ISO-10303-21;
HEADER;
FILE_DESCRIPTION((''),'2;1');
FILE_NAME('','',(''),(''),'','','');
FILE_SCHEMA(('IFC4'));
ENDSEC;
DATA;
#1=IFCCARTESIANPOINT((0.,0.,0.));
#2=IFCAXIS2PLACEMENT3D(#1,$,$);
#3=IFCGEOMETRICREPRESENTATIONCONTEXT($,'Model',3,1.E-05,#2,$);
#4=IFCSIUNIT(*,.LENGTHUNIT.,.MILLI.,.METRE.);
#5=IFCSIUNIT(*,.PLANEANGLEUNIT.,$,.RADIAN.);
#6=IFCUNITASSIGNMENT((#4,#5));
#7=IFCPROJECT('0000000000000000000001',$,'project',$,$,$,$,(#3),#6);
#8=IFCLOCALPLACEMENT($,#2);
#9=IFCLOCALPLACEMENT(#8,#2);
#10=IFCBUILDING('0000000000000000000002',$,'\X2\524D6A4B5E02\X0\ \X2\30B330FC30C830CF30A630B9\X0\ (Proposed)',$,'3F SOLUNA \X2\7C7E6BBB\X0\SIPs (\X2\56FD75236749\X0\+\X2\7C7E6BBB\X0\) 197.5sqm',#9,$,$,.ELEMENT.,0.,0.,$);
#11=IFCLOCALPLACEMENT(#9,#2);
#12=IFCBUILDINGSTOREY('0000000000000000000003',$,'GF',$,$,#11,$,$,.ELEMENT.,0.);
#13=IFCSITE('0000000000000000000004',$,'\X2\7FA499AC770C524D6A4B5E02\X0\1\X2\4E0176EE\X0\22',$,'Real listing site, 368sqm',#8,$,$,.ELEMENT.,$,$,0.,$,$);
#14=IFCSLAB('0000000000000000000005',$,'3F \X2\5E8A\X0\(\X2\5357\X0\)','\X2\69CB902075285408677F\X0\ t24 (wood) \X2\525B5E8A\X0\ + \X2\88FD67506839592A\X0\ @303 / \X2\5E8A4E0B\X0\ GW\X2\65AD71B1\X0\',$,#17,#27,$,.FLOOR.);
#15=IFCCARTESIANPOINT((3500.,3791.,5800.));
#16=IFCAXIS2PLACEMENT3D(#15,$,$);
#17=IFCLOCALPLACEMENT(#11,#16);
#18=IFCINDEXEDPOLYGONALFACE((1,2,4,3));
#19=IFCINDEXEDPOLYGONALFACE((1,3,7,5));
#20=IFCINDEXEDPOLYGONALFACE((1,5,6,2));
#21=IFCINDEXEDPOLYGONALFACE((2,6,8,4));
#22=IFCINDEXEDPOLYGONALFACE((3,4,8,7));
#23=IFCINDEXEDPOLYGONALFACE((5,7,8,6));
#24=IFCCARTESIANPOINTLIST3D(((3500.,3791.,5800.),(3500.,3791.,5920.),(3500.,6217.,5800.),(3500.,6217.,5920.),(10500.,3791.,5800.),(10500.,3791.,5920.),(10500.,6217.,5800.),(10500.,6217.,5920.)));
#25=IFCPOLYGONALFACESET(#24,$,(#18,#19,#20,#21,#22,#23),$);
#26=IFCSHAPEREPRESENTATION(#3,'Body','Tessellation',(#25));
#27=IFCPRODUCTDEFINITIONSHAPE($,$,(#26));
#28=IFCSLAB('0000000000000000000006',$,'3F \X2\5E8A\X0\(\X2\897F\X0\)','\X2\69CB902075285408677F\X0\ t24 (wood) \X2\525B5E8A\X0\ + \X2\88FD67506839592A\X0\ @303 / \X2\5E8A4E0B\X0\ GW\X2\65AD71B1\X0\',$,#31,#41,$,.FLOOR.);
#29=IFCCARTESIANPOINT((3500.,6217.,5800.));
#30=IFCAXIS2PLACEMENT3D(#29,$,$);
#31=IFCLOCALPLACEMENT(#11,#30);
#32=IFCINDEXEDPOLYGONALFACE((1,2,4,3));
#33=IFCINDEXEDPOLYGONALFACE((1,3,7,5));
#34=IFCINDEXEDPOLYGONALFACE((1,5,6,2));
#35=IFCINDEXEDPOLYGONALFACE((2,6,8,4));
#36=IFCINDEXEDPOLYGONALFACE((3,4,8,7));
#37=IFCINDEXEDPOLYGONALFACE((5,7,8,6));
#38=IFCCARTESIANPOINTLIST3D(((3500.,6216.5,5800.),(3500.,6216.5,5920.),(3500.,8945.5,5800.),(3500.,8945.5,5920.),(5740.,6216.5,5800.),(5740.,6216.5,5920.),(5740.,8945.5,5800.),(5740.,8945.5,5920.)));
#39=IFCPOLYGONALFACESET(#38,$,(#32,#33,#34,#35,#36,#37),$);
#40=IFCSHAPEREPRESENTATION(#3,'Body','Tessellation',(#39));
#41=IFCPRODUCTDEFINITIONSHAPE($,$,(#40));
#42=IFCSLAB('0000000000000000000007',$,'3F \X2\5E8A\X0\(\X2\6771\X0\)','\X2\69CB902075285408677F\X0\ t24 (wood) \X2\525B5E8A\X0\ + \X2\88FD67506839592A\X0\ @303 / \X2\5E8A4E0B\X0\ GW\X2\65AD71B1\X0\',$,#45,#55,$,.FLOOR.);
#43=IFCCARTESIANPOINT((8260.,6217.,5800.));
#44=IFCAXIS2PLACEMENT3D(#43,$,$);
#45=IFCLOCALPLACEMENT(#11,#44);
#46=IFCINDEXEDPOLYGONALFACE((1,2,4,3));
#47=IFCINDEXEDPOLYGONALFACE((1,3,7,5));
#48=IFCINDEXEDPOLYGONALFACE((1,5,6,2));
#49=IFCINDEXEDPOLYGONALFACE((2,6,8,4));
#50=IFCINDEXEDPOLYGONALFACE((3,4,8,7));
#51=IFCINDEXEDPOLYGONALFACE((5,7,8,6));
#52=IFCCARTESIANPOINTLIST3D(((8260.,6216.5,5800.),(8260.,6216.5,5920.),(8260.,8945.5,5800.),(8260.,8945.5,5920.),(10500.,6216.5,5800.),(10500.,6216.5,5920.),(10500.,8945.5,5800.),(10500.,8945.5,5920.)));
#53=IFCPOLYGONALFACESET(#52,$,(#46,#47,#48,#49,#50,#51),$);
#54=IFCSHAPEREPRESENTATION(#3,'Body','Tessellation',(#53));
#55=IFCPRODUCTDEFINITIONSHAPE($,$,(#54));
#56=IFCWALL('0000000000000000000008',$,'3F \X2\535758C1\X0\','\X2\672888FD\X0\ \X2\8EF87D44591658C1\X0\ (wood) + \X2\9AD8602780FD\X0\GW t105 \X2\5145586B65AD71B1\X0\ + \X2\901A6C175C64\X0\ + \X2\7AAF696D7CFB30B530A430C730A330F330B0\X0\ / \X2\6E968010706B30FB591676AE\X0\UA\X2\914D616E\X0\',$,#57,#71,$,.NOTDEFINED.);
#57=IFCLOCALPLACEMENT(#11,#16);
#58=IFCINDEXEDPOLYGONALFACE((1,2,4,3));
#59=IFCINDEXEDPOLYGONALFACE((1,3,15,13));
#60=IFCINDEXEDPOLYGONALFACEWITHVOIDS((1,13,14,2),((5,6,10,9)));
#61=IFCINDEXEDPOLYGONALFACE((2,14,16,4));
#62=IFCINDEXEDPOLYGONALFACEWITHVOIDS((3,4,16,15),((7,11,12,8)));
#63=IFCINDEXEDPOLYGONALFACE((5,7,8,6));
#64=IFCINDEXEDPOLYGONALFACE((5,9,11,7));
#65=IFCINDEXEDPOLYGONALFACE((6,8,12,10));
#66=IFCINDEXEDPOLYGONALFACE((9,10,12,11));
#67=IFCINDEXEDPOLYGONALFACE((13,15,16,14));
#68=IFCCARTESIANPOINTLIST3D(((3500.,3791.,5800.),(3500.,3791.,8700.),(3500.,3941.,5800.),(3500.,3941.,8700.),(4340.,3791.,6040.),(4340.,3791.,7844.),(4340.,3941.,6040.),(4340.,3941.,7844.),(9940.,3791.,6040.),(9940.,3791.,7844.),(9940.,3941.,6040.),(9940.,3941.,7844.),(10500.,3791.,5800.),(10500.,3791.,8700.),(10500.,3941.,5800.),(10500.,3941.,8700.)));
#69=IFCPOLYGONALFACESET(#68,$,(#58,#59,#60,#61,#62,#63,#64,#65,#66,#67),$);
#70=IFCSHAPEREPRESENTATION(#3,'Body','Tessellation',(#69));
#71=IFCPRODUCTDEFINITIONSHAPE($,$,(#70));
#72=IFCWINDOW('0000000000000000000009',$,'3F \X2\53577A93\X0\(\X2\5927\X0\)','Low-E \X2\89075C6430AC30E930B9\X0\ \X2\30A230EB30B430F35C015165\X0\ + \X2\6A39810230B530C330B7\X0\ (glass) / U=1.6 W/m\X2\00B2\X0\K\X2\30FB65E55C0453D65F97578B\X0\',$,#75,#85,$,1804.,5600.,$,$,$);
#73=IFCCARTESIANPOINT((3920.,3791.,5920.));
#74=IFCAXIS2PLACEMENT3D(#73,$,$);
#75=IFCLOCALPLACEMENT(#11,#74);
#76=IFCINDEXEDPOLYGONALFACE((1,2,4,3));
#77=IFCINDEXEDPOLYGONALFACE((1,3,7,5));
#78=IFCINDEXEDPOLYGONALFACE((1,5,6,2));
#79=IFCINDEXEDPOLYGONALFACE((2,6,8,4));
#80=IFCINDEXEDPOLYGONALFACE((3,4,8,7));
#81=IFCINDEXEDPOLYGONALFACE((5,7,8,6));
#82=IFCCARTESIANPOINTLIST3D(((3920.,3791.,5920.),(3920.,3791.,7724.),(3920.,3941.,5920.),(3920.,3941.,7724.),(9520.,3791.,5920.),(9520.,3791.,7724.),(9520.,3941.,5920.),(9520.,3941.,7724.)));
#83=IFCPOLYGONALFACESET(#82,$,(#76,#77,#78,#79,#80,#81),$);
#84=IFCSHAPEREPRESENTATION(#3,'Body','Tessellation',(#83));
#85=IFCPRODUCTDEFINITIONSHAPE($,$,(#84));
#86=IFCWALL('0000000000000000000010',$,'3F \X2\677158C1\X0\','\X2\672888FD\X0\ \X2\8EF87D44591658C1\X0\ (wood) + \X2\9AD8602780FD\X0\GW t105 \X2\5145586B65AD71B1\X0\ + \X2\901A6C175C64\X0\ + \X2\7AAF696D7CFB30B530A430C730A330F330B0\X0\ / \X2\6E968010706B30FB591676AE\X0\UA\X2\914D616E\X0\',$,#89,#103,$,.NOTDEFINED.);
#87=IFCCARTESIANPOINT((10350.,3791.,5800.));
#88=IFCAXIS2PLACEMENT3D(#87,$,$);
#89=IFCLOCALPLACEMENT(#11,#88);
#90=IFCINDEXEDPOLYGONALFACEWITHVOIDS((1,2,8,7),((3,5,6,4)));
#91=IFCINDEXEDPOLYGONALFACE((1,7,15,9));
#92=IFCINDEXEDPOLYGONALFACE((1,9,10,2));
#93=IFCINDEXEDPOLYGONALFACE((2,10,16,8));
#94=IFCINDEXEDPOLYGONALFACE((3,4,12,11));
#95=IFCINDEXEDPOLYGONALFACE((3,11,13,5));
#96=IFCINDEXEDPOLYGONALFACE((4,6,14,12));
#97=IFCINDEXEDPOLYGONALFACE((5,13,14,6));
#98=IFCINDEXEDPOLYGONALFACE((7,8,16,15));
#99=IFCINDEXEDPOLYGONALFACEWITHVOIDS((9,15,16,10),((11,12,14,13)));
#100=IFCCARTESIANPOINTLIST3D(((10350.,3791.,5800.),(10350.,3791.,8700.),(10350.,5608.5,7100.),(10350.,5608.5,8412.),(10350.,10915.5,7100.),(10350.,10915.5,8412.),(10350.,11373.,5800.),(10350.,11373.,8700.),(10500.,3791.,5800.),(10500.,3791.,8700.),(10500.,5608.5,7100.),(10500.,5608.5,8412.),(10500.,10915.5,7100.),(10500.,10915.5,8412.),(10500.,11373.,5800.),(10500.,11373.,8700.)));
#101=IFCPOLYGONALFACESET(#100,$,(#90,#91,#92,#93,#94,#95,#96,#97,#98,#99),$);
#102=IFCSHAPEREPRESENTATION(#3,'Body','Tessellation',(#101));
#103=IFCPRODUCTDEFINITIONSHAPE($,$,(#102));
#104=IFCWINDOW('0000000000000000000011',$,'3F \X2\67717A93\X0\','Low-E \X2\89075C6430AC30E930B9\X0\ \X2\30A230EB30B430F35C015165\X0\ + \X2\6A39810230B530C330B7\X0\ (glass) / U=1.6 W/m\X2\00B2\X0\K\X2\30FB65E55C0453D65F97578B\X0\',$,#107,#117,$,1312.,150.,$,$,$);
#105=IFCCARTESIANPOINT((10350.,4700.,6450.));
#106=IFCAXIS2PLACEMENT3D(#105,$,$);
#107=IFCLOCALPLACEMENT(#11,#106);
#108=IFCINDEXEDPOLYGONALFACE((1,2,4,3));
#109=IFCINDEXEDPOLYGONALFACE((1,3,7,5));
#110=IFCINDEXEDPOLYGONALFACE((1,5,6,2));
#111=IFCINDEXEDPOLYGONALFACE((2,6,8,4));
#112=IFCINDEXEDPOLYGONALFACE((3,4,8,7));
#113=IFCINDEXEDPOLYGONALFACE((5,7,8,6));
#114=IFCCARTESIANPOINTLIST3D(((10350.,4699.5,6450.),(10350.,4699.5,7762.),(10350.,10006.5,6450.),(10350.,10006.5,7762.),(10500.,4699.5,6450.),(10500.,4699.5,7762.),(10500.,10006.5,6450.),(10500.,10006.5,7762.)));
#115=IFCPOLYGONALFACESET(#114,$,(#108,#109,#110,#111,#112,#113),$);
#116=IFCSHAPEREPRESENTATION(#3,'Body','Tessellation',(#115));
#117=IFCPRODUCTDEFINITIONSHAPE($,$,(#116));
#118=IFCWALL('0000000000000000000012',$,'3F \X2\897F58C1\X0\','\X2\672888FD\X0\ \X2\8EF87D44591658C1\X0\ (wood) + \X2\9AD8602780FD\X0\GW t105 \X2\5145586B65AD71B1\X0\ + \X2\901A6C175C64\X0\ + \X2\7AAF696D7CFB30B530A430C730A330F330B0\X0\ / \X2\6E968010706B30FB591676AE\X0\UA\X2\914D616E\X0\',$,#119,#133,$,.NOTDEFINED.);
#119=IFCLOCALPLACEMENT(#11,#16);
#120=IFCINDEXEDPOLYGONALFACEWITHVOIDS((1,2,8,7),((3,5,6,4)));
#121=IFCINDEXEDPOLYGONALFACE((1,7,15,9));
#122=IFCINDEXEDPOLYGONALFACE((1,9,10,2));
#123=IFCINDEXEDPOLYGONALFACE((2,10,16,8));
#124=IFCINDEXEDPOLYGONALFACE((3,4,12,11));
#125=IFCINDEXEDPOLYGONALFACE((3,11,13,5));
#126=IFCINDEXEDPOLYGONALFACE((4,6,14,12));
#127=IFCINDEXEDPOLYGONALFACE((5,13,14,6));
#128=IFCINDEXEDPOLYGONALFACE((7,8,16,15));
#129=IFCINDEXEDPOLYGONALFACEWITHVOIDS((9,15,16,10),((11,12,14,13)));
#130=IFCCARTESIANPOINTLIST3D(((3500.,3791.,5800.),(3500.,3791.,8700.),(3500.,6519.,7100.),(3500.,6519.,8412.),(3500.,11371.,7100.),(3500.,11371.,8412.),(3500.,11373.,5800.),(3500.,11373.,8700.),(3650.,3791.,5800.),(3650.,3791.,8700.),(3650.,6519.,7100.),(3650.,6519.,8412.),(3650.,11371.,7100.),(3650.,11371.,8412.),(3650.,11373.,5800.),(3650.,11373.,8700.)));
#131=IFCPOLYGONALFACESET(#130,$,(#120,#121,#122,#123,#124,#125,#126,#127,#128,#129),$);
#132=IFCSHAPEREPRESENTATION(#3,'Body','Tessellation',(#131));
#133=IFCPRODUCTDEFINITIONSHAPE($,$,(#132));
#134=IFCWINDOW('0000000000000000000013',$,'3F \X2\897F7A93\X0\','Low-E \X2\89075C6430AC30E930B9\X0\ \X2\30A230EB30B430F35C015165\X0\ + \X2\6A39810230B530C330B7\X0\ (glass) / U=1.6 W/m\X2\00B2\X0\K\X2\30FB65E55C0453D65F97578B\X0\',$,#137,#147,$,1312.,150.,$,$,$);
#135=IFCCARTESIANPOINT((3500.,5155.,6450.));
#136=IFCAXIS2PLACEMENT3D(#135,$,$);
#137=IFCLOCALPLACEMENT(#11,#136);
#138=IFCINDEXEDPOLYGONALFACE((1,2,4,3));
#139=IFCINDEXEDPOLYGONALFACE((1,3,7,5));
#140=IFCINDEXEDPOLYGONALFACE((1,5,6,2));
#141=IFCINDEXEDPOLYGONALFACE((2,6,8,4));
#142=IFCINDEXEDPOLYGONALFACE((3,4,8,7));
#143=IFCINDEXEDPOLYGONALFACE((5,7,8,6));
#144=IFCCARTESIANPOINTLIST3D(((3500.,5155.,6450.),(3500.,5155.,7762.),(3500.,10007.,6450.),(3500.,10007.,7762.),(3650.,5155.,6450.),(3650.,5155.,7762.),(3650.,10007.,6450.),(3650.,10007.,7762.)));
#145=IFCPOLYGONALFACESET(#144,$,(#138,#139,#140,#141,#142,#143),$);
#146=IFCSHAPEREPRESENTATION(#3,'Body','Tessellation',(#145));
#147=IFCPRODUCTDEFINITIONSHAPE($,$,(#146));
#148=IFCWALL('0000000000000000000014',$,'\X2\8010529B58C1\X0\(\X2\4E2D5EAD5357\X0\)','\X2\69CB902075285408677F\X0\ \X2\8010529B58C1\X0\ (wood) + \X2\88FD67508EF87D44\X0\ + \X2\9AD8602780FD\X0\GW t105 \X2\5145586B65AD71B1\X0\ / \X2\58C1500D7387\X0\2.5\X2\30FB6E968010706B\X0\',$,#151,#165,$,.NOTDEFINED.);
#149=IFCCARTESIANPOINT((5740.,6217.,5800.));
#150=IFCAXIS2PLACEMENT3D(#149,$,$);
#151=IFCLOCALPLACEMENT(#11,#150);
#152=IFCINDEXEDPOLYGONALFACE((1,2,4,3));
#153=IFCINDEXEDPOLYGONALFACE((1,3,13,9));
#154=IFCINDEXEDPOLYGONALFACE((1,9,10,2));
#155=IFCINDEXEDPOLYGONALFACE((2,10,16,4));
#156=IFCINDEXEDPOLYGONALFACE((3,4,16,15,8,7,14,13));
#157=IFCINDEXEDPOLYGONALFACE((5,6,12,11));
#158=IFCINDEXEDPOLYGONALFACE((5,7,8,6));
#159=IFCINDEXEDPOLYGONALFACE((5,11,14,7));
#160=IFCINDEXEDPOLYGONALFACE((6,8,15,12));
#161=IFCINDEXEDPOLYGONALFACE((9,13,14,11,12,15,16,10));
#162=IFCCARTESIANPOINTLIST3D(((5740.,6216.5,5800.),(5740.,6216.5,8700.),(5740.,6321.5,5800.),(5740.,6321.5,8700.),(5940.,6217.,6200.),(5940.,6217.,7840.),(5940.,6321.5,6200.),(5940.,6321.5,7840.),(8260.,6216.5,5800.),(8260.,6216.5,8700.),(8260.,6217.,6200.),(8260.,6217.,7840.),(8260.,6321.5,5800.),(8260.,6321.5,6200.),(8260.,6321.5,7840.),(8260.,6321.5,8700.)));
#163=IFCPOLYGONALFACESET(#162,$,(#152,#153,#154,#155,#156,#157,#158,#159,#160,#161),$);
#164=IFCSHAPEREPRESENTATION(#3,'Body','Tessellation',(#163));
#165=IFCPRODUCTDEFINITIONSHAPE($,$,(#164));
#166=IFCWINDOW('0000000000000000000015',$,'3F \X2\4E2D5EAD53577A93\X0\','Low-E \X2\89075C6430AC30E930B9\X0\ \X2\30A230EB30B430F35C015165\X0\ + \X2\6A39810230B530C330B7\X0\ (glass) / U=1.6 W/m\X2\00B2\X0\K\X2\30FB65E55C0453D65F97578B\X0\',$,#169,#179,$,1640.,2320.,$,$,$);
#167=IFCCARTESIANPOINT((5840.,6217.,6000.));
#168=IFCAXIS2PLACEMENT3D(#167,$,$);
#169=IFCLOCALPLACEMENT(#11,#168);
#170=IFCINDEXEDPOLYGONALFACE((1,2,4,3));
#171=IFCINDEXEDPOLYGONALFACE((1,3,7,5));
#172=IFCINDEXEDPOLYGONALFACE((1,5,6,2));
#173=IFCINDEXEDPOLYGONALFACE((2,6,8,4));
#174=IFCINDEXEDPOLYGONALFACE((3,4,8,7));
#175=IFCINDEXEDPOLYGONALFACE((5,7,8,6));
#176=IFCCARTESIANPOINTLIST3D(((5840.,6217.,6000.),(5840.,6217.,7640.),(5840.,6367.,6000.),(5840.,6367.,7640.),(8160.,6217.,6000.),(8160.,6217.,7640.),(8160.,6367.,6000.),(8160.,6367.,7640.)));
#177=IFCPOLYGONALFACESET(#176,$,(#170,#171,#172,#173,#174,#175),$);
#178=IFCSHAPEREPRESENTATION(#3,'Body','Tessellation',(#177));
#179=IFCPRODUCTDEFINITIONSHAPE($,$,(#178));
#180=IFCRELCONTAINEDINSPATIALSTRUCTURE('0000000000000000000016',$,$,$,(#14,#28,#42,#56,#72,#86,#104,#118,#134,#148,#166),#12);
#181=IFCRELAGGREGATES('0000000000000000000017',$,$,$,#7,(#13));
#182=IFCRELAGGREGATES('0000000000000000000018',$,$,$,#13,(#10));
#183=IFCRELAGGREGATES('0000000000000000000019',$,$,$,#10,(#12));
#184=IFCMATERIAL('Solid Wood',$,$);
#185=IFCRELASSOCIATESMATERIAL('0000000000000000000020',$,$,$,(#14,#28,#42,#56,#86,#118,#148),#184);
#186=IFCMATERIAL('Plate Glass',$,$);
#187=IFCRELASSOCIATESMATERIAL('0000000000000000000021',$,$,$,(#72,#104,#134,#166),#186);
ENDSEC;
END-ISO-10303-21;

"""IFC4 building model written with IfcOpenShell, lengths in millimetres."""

from ifc_helpers import new_model, si_unit, frame, frame_2d, origin, place, context, project, spatial, rectangle, extrude, material, element, fill, save


model = new_model("IFC4")

# Units and contexts
model_context = context("Model", 3, precision=1e-05, world=origin())
ifc_project = project(units=[si_unit("LENGTHUNIT", "METRE", prefix="MILLI"), si_unit("PLANEANGLEUNIT", "RADIAN")], contexts=[model_context])

# Site, building, storey
site_placement = place(None, origin())
site = spatial("IfcSite", under=ifc_project, at=site_placement, Name="群馬県前橋市1丁目22", ObjectType="Real listing site, 368sqm", CompositionType="ELEMENT", RefElevation=0.0)
building_placement = place(site_placement, origin())
building = spatial("IfcBuilding", under=site, at=building_placement, Name="前橋市 コートハウス (Proposed)", ObjectType="3F SOLUNA 籾殻SIPs (国産杉+籾殻) 197.5sqm", CompositionType="ELEMENT", ElevationOfRefHeight=0.0, ElevationOfTerrain=0.0)
storey_placement = place(building_placement, origin())
storey = spatial("IfcBuildingStorey", under=building, at=storey_placement, Name="GF", CompositionType="ELEMENT", Elevation=0.0)

# Slabs
ifc_material_1 = material(Name="Solid Wood")
slab_1_placement = place(storey_placement, frame((3500.0, 3791.0, 5800.0)))
element("IfcSlab", 1, at=slab_1_placement, inside=storey, material=ifc_material_1, Name="3F 床(南)", Description="構造用合板 t24 (wood) 剛床 + 製材根太 @303 / 床下 GW断熱", PredefinedType="FLOOR", context=model_context, shape_type="SweptSolid", body=[
    extrude(rectangle(XDim=7000.0, YDim=2426.0, at=frame_2d((3500.0, 1213.0))), frame((3500.0, 3791.0, 5800.0)), (0.0, 0.0, 1.0), 120.0),
])
slab_2_placement = place(storey_placement, frame((3500.0, 6217.0, 5800.0)))
element("IfcSlab", 2, at=slab_2_placement, inside=storey, material=ifc_material_1, Name="3F 床(西)", Description="構造用合板 t24 (wood) 剛床 + 製材根太 @303 / 床下 GW断熱", PredefinedType="FLOOR", context=model_context, shape_type="SweptSolid", body=[
    extrude(rectangle(XDim=2240.0, YDim=2729.0, at=frame_2d((1120.0, 1364.0))), frame((3500.0, 6217.0, 5800.0)), (0.0, 0.0, 1.0), 120.0),
])
slab_3_placement = place(storey_placement, frame((8260.0, 6217.0, 5800.0)))
element("IfcSlab", 3, at=slab_3_placement, inside=storey, material=ifc_material_1, Name="3F 床(東)", Description="構造用合板 t24 (wood) 剛床 + 製材根太 @303 / 床下 GW断熱", PredefinedType="FLOOR", context=model_context, shape_type="SweptSolid", body=[
    extrude(rectangle(XDim=2240.0, YDim=2729.0, at=frame_2d((1120.0, 1364.0))), frame((8260.0, 6217.0, 5800.0)), (0.0, 0.0, 1.0), 120.0),
])

# Walls, openings, windows
wall_1_placement = place(storey_placement, frame((3500.0, 3791.0, 5800.0)))
wall_1 = element("IfcWall", 4, at=wall_1_placement, inside=storey, material=ifc_material_1, Name="3F 南壁", Description="木製 軸組外壁 (wood) + 高性能GW t105 充填断熱 + 通気層 + 窯業系サイディング / 準耐火・外皮UA配慮", PredefinedType="NOTDEFINED", context=model_context, shape_type="SweptSolid", body=[
    extrude(rectangle(XDim=7000.0, YDim=150.0, at=frame_2d((3500.0, 75.0))), frame((3500.0, 3791.0, 5800.0)), (0.0, 0.0, 1.0), 2900.0),
])
opening_1_placement = place(storey_placement, frame((3920.0, 3791.0, 5920.0)))
opening_1 = element("IfcOpeningElement", 5, at=opening_1_placement, cuts=wall_1, PredefinedType="NOTDEFINED", context=model_context, shape_type="SweptSolid", body=[
    extrude(rectangle(XDim=5600.0, YDim=150.0, at=frame_2d((2800.0, 75.0))), frame((3920.0, 3791.0, 5920.0)), (0.0, 0.0, 1.0), 1804.0),
])
ifc_material_2 = material(Name="Plate Glass")
window_1_placement = place(storey_placement, frame((3920.0, 3791.0, 5920.0)))
window_1 = element("IfcWindow", 6, at=window_1_placement, inside=storey, material=ifc_material_2, Name="3F 南窓(大)", Description="Low-E 複層ガラス アルゴン封入 + 樹脂サッシ (glass) / U=1.6 W/m²K・日射取得型", OverallHeight=1804.0, OverallWidth=5600.0, context=model_context, shape_type="SweptSolid", body=[
    extrude(rectangle(XDim=5600.0, YDim=150.0, at=frame_2d((2800.0, 75.0))), frame((3920.0, 3791.0, 5920.0)), (0.0, 0.0, 1.0), 1804.0),
])
fill(opening_1, window_1)
wall_2_placement = place(storey_placement, frame((10350.0, 3791.0, 5800.0)))
wall_2 = element("IfcWall", 7, at=wall_2_placement, inside=storey, material=ifc_material_1, Name="3F 東壁", Description="木製 軸組外壁 (wood) + 高性能GW t105 充填断熱 + 通気層 + 窯業系サイディング / 準耐火・外皮UA配慮", PredefinedType="NOTDEFINED", context=model_context, shape_type="SweptSolid", body=[
    extrude(rectangle(XDim=150.0, YDim=7582.0, at=frame_2d((75.0, 3791.0))), frame((10350.0, 3791.0, 5800.0)), (0.0, 0.0, 1.0), 2900.0),
])
opening_2_placement = place(storey_placement, frame((10350.0, 4700.0, 6450.0)))
opening_2 = element("IfcOpeningElement", 8, at=opening_2_placement, cuts=wall_2, PredefinedType="NOTDEFINED", context=model_context, shape_type="SweptSolid", body=[
    extrude(rectangle(XDim=150.0, YDim=5307.0, at=frame_2d((75.0, 2653.0))), frame((10350.0, 4700.0, 6450.0)), (0.0, 0.0, 1.0), 1312.0),
])
window_2_placement = place(storey_placement, frame((10350.0, 4700.0, 6450.0)))
window_2 = element("IfcWindow", 9, at=window_2_placement, inside=storey, material=ifc_material_2, Name="3F 東窓", Description="Low-E 複層ガラス アルゴン封入 + 樹脂サッシ (glass) / U=1.6 W/m²K・日射取得型", OverallHeight=1312.0, OverallWidth=150.0, context=model_context, shape_type="SweptSolid", body=[
    extrude(rectangle(XDim=150.0, YDim=5307.0, at=frame_2d((75.0, 2653.0))), frame((10350.0, 4700.0, 6450.0)), (0.0, 0.0, 1.0), 1312.0),
])
fill(opening_2, window_2)
wall_3_placement = place(storey_placement, frame((3500.0, 3791.0, 5800.0)))
wall_3 = element("IfcWall", 10, at=wall_3_placement, inside=storey, material=ifc_material_1, Name="3F 西壁", Description="木製 軸組外壁 (wood) + 高性能GW t105 充填断熱 + 通気層 + 窯業系サイディング / 準耐火・外皮UA配慮", PredefinedType="NOTDEFINED", context=model_context, shape_type="SweptSolid", body=[
    extrude(rectangle(XDim=150.0, YDim=7582.0, at=frame_2d((75.0, 3791.0))), frame((3500.0, 3791.0, 5800.0)), (0.0, 0.0, 1.0), 2900.0),
])
opening_3_placement = place(storey_placement, frame((3500.0, 5155.0, 6450.0)))
opening_3 = element("IfcOpeningElement", 11, at=opening_3_placement, cuts=wall_3, PredefinedType="NOTDEFINED", context=model_context, shape_type="SweptSolid", body=[
    extrude(rectangle(XDim=150.0, YDim=4852.0, at=frame_2d((75.0, 2426.0))), frame((3500.0, 5155.0, 6450.0)), (0.0, 0.0, 1.0), 1312.0),
])
window_3_placement = place(storey_placement, frame((3500.0, 5155.0, 6450.0)))
window_3 = element("IfcWindow", 12, at=window_3_placement, inside=storey, material=ifc_material_2, Name="3F 西窓", Description="Low-E 複層ガラス アルゴン封入 + 樹脂サッシ (glass) / U=1.6 W/m²K・日射取得型", OverallHeight=1312.0, OverallWidth=150.0, context=model_context, shape_type="SweptSolid", body=[
    extrude(rectangle(XDim=150.0, YDim=4852.0, at=frame_2d((75.0, 2426.0))), frame((3500.0, 5155.0, 6450.0)), (0.0, 0.0, 1.0), 1312.0),
])
fill(opening_3, window_3)
wall_4_placement = place(storey_placement, frame((5740.0, 6217.0, 5800.0)))
wall_4 = element("IfcWall", 13, at=wall_4_placement, inside=storey, material=ifc_material_1, Name="耐力壁(中庭南)", Description="構造用合板 耐力壁 (wood) + 製材軸組 + 高性能GW t105 充填断熱 / 壁倍率2.5・準耐火", PredefinedType="NOTDEFINED", context=model_context, shape_type="SweptSolid", body=[
    extrude(rectangle(XDim=2520.0, YDim=105.0, at=frame_2d((1260.0, 52.0))), frame((5740.0, 6217.0, 5800.0)), (0.0, 0.0, 1.0), 2900.0),
])
opening_4_placement = place(storey_placement, frame((5840.0, 6217.0, 6000.0)))
opening_4 = element("IfcOpeningElement", 14, at=opening_4_placement, cuts=wall_4, PredefinedType="NOTDEFINED", context=model_context, shape_type="SweptSolid", body=[
    extrude(rectangle(XDim=2320.0, YDim=150.0, at=frame_2d((1160.0, 75.0))), frame((5840.0, 6217.0, 6000.0)), (0.0, 0.0, 1.0), 1640.0),
])
window_4_placement = place(storey_placement, frame((5840.0, 6217.0, 6000.0)))
window_4 = element("IfcWindow", 15, at=window_4_placement, inside=storey, material=ifc_material_2, Name="3F 中庭南窓", Description="Low-E 複層ガラス アルゴン封入 + 樹脂サッシ (glass) / U=1.6 W/m²K・日射取得型", OverallHeight=1640.0, OverallWidth=2320.0, context=model_context, shape_type="SweptSolid", body=[
    extrude(rectangle(XDim=2320.0, YDim=150.0, at=frame_2d((1160.0, 75.0))), frame((5840.0, 6217.0, 6000.0)), (0.0, 0.0, 1.0), 1640.0),
])
fill(opening_4, window_4)

save(model, "model.ifc")
